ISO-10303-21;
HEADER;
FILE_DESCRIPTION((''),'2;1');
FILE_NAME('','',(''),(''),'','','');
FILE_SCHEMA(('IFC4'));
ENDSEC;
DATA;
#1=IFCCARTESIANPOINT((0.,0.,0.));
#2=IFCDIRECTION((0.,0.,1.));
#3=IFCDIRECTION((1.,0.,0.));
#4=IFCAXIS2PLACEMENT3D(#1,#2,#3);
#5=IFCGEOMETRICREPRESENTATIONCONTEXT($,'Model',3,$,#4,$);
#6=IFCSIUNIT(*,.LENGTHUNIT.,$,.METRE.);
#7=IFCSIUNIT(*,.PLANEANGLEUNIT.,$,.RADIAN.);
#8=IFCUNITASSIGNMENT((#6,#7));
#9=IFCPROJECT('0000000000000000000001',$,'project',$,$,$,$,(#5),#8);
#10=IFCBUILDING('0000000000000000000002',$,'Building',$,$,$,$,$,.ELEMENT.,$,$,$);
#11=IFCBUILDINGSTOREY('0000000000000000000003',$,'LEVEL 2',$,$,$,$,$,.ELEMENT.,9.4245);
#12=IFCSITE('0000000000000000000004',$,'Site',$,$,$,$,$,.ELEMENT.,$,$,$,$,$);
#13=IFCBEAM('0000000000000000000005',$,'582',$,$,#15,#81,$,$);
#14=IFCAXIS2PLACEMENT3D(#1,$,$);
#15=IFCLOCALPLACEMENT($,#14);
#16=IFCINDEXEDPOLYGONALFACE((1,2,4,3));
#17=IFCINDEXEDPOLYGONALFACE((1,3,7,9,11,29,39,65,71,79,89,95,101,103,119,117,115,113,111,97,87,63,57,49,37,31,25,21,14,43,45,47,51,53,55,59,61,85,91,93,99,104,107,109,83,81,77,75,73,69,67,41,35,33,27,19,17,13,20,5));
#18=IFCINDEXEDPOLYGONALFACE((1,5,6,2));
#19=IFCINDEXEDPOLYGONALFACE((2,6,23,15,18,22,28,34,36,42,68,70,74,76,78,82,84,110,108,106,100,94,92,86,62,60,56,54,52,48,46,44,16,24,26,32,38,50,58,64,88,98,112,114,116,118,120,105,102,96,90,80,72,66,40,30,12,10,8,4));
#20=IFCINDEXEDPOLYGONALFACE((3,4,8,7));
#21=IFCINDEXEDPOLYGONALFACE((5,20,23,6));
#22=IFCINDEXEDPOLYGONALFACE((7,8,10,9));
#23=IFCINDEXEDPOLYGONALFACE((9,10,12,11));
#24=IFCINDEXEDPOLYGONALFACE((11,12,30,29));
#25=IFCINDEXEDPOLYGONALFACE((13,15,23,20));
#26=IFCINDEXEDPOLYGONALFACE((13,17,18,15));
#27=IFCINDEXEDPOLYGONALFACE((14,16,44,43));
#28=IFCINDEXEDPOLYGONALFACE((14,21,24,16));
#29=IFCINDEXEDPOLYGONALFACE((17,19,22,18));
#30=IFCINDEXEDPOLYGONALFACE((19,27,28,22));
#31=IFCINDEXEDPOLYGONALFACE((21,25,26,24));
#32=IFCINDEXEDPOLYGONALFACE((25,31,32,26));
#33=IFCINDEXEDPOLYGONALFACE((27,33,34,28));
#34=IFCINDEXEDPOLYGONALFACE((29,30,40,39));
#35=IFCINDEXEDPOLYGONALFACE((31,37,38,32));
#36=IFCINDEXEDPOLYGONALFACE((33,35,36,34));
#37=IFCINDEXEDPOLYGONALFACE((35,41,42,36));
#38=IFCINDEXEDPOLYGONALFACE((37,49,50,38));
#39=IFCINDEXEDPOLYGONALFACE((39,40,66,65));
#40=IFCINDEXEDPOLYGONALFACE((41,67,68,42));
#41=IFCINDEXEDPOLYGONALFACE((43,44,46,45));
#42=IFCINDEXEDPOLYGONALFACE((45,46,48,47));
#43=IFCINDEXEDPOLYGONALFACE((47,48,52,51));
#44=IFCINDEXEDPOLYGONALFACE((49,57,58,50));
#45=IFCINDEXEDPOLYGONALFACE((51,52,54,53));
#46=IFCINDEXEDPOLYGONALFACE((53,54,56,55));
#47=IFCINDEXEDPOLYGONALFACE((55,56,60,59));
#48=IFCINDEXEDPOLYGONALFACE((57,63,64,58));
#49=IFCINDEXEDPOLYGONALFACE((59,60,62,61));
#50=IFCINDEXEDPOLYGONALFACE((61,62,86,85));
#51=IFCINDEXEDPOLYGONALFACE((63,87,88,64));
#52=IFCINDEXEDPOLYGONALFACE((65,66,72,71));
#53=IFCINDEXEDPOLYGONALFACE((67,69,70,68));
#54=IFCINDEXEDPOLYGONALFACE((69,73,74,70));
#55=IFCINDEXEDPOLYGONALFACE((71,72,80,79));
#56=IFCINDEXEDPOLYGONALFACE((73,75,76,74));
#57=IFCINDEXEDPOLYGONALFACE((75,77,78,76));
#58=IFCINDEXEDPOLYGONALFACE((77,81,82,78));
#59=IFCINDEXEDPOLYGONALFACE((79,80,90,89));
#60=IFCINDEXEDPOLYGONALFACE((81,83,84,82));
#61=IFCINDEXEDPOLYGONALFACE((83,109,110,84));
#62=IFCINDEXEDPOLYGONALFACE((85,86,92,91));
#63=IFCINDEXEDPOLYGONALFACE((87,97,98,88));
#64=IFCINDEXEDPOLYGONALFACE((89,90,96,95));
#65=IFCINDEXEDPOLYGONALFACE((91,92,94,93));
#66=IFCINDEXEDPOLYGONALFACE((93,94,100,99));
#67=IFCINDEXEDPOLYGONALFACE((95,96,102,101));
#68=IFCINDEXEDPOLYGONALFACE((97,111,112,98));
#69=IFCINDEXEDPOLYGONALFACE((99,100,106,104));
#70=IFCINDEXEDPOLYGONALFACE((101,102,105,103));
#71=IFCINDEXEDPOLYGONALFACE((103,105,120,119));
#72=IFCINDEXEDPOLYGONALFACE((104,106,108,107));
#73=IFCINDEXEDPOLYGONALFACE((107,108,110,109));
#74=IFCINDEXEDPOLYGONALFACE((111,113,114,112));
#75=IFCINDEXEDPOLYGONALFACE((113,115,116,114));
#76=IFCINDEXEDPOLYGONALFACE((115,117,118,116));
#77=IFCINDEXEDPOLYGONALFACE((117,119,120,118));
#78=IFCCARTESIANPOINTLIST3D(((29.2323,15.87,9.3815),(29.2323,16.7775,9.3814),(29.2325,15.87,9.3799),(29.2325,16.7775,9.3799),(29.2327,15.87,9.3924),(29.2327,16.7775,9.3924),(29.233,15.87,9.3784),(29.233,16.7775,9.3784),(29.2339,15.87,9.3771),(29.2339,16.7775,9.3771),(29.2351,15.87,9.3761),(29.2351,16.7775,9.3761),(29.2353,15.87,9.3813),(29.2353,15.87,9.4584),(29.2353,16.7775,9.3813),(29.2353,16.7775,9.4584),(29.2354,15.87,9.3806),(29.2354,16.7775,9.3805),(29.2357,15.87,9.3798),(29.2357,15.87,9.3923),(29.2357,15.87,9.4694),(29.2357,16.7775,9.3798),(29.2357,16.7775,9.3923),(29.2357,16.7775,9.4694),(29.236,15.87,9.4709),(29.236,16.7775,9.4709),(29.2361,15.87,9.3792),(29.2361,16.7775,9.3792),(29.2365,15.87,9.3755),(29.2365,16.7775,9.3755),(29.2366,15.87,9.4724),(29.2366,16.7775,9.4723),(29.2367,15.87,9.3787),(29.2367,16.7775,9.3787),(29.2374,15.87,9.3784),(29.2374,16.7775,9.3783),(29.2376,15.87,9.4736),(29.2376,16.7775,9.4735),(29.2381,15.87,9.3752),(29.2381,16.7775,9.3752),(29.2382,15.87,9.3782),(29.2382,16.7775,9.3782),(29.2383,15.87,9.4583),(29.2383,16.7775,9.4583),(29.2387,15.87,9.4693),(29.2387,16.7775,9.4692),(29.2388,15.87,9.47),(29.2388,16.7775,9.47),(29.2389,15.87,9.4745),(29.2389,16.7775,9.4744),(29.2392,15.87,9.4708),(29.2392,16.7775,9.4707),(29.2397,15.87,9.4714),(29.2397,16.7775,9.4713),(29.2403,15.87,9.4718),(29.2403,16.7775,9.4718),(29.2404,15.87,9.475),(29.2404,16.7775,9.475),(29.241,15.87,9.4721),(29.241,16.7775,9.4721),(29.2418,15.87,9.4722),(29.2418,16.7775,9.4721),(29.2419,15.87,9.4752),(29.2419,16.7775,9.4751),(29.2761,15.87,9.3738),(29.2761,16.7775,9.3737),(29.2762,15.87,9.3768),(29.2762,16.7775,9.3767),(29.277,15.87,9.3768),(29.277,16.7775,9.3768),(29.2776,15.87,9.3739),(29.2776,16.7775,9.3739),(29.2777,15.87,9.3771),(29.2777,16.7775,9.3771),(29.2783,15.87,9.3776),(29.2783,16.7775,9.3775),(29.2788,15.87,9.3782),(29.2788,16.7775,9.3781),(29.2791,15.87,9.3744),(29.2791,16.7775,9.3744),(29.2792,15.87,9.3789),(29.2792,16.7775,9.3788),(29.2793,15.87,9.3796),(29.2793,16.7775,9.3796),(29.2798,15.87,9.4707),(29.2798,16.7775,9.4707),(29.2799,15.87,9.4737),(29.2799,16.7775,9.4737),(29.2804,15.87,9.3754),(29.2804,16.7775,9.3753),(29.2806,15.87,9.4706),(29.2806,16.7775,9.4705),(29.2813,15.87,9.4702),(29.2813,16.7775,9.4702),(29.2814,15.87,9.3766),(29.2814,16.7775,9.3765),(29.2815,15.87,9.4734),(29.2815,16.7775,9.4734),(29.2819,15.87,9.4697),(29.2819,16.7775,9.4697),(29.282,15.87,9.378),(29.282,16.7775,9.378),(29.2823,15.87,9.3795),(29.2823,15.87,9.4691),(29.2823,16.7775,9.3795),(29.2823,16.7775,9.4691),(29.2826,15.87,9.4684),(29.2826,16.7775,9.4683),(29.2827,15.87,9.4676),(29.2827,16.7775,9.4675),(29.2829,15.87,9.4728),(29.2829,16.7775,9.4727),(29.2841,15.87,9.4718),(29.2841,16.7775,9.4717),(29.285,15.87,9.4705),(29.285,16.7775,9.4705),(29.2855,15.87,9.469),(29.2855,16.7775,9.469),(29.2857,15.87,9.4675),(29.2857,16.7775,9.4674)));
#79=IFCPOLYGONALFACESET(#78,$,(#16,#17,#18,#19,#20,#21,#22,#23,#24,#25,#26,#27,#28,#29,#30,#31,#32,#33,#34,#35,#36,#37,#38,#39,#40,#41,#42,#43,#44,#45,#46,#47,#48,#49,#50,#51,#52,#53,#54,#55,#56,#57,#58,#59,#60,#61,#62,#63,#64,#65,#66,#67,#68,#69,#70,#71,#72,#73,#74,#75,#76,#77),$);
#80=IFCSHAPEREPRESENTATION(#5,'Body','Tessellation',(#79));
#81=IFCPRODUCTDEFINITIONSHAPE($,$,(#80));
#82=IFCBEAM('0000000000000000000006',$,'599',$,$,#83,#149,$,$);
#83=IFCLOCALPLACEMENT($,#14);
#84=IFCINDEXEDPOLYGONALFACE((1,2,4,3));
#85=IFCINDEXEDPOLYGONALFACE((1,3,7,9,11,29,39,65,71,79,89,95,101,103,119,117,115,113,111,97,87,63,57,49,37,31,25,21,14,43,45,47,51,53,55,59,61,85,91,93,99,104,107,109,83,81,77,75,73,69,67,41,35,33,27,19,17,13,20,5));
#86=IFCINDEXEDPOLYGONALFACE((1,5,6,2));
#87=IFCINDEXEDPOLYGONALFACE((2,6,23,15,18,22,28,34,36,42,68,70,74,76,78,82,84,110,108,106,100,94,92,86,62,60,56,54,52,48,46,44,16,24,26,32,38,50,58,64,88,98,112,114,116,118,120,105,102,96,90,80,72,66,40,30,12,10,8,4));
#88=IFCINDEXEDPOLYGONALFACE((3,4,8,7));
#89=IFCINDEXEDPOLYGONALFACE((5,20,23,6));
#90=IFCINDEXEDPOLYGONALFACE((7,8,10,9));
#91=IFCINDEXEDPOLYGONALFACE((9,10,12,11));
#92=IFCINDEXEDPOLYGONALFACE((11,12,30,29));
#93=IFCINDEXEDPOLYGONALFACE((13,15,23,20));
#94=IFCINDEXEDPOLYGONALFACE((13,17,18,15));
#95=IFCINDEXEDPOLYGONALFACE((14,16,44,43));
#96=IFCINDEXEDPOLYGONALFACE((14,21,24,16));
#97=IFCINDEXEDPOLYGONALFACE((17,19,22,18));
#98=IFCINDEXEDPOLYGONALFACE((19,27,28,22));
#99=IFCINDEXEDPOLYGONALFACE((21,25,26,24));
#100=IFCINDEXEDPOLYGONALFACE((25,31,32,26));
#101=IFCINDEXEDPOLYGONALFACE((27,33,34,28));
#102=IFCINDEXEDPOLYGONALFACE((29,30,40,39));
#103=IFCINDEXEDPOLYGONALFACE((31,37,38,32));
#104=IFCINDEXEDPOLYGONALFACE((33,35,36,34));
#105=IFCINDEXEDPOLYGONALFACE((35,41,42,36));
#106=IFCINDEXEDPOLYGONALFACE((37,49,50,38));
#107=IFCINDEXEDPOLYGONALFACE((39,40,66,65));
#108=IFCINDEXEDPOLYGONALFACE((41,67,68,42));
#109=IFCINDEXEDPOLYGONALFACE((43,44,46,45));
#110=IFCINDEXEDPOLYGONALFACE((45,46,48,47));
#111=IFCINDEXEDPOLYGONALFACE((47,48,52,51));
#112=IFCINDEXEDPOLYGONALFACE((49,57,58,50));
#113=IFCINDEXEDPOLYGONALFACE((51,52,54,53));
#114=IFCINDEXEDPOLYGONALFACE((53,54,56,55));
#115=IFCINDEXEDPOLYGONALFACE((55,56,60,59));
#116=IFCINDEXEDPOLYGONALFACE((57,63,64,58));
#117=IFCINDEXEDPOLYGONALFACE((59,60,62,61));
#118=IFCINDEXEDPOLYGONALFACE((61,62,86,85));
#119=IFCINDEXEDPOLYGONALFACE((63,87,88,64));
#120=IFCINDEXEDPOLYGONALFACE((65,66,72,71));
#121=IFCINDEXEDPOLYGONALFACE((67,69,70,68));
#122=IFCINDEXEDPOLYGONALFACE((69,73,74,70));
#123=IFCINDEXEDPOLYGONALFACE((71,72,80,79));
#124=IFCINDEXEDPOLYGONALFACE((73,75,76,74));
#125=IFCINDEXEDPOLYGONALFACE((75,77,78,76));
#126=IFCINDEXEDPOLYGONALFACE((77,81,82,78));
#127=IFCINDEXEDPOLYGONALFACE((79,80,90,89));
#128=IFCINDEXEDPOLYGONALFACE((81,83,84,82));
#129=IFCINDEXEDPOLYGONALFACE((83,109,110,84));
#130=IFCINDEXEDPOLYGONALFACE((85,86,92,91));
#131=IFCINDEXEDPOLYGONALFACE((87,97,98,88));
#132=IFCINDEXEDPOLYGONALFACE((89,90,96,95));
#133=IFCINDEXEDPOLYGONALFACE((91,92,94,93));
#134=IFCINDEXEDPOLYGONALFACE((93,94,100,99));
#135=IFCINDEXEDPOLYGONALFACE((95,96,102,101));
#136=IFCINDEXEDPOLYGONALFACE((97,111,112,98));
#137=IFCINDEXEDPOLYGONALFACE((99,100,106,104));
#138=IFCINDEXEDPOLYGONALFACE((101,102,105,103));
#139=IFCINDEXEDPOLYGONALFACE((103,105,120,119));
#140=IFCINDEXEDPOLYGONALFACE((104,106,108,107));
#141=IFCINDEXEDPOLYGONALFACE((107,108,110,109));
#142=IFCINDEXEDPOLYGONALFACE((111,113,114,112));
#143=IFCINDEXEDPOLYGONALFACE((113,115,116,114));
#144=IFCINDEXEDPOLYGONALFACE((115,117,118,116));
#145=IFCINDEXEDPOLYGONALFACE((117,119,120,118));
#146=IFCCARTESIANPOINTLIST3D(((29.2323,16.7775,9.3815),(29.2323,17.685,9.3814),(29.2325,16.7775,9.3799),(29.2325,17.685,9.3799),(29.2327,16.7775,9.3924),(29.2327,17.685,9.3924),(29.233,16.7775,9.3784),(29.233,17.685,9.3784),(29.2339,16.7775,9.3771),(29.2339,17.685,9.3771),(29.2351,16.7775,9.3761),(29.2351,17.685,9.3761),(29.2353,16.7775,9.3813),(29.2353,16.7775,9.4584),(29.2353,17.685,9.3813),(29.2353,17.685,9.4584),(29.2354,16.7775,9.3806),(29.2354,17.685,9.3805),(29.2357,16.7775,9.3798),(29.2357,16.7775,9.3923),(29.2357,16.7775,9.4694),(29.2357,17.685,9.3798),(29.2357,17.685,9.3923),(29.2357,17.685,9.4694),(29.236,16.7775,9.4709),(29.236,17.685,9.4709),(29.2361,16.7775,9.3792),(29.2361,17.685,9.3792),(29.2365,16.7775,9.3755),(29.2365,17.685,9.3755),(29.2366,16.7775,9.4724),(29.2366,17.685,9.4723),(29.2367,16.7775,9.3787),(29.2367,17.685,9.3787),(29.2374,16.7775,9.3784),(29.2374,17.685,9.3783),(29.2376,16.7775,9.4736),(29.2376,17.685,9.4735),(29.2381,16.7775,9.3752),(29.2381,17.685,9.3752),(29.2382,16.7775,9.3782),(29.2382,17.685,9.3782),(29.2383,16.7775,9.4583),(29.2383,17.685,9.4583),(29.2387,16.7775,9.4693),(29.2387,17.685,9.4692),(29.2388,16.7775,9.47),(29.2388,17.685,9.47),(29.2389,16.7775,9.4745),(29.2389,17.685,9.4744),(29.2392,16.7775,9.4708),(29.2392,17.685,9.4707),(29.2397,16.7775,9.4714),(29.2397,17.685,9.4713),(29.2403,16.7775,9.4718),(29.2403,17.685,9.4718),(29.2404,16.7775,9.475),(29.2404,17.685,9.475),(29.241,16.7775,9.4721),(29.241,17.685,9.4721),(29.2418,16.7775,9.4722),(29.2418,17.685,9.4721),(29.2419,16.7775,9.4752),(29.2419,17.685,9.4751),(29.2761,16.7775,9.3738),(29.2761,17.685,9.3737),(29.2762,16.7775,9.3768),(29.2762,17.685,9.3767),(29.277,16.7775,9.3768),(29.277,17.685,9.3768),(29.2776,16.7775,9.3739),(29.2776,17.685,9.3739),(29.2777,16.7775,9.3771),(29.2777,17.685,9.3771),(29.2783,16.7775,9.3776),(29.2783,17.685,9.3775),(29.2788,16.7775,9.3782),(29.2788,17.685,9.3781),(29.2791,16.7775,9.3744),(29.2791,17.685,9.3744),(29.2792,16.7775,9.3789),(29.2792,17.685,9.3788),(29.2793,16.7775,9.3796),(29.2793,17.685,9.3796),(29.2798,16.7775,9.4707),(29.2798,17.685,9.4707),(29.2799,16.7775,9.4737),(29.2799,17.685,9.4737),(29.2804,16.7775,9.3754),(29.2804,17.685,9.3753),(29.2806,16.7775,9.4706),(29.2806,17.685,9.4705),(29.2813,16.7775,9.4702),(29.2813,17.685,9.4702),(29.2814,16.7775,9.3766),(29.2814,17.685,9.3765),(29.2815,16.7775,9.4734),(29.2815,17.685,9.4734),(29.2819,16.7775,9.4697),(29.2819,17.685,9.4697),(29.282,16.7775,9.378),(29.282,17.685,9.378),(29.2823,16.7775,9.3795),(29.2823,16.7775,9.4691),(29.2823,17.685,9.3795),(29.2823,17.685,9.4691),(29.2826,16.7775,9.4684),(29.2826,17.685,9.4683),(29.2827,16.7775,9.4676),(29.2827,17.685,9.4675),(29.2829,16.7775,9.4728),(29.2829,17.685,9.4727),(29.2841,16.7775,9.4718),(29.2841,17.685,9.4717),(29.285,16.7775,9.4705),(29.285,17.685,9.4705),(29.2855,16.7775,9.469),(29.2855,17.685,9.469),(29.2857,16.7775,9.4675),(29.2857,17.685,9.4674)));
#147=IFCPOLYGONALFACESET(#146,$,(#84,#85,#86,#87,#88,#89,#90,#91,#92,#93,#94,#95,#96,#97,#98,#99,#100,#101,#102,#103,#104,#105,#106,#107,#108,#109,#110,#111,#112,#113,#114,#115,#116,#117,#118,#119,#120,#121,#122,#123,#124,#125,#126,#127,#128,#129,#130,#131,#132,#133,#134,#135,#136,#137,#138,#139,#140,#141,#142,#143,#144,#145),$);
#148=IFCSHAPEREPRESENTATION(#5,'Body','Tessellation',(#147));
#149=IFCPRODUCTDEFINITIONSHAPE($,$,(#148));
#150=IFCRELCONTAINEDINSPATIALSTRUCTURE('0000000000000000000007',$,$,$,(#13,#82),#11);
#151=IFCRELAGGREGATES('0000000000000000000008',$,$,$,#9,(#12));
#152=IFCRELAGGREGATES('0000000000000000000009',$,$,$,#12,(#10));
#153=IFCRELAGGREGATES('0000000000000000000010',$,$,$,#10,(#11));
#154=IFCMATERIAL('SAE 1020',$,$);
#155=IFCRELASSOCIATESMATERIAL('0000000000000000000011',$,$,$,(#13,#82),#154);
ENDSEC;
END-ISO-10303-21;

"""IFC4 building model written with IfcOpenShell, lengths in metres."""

from ifc_helpers import new_model, si_unit, frame, origin_with_axes, origin_2d_with_axis, place, context, project, spatial, c_section, extrude, material, material_profile, profile_set, profile_usage, element, save


model = new_model("IFC4")

# Units and contexts
model_context = context("Model", 3, world=origin_with_axes())
ifc_project = project(units=[si_unit("LENGTHUNIT", "METRE"), si_unit("PLANEANGLEUNIT", "RADIAN")], contexts=[model_context])

# Site, building, storey
site = spatial("IfcSite", under=ifc_project, Name="Site", CompositionType="ELEMENT")
building = spatial("IfcBuilding", under=site, Name="Building", CompositionType="ELEMENT")
storey = spatial("IfcBuildingStorey", under=building, Name="LEVEL 2", CompositionType="ELEMENT", Elevation=9.4245)

# Beams
ifc_material = material(Name="SAE 1020")
ifc_material_profile_1 = material_profile(ifc_material, c_section(Depth=0.1, Width=0.05, WallThickness=0.003, Girth=0.017, InternalFilletRadius=0.003, at=origin_2d_with_axis()))
ifc_profile_set_1 = profile_set([ifc_material_profile_1])
ifc_profile_usage_1 = profile_usage(ifc_profile_set_1, cardinal=10)
beam_1_placement = place(None, frame((29.259, 15.87, 9.4245), z_axis=(0.0, 1.0, -0.00003), x_axis=(-0.999256, 0.000001, 0.038562)))
element("IfcBeam", 1, at=beam_1_placement, inside=storey, material=ifc_profile_usage_1, Name="582", context=model_context, shape_type="SweptSolid", body=[
    extrude(c_section(Depth=0.1, Width=0.05, WallThickness=0.003, Girth=0.017, InternalFilletRadius=0.003, at=origin_2d_with_axis()), origin_with_axes(), (0.0, 0.0, 1.0), 0.9075),
])
ifc_material_profile_2 = material_profile(ifc_material, c_section(Depth=0.1, Width=0.05, WallThickness=0.003, Girth=0.017, InternalFilletRadius=0.003, at=origin_2d_with_axis()))
ifc_profile_set_2 = profile_set([ifc_material_profile_2])
ifc_profile_usage_2 = profile_usage(ifc_profile_set_2, cardinal=10)
beam_2_placement = place(None, frame((29.259, 16.7775, 9.4245), z_axis=(0.0, 1.0, -0.00003), x_axis=(-0.999256, 0.000001, 0.038562)))
element("IfcBeam", 2, at=beam_2_placement, inside=storey, material=ifc_profile_usage_2, Name="599", context=model_context, shape_type="SweptSolid", body=[
    extrude(c_section(Depth=0.1, Width=0.05, WallThickness=0.003, Girth=0.017, InternalFilletRadius=0.003, at=origin_2d_with_axis()), origin_with_axes(), (0.0, 0.0, 1.0), 0.9075),
])

save(model, "model.ifc")
